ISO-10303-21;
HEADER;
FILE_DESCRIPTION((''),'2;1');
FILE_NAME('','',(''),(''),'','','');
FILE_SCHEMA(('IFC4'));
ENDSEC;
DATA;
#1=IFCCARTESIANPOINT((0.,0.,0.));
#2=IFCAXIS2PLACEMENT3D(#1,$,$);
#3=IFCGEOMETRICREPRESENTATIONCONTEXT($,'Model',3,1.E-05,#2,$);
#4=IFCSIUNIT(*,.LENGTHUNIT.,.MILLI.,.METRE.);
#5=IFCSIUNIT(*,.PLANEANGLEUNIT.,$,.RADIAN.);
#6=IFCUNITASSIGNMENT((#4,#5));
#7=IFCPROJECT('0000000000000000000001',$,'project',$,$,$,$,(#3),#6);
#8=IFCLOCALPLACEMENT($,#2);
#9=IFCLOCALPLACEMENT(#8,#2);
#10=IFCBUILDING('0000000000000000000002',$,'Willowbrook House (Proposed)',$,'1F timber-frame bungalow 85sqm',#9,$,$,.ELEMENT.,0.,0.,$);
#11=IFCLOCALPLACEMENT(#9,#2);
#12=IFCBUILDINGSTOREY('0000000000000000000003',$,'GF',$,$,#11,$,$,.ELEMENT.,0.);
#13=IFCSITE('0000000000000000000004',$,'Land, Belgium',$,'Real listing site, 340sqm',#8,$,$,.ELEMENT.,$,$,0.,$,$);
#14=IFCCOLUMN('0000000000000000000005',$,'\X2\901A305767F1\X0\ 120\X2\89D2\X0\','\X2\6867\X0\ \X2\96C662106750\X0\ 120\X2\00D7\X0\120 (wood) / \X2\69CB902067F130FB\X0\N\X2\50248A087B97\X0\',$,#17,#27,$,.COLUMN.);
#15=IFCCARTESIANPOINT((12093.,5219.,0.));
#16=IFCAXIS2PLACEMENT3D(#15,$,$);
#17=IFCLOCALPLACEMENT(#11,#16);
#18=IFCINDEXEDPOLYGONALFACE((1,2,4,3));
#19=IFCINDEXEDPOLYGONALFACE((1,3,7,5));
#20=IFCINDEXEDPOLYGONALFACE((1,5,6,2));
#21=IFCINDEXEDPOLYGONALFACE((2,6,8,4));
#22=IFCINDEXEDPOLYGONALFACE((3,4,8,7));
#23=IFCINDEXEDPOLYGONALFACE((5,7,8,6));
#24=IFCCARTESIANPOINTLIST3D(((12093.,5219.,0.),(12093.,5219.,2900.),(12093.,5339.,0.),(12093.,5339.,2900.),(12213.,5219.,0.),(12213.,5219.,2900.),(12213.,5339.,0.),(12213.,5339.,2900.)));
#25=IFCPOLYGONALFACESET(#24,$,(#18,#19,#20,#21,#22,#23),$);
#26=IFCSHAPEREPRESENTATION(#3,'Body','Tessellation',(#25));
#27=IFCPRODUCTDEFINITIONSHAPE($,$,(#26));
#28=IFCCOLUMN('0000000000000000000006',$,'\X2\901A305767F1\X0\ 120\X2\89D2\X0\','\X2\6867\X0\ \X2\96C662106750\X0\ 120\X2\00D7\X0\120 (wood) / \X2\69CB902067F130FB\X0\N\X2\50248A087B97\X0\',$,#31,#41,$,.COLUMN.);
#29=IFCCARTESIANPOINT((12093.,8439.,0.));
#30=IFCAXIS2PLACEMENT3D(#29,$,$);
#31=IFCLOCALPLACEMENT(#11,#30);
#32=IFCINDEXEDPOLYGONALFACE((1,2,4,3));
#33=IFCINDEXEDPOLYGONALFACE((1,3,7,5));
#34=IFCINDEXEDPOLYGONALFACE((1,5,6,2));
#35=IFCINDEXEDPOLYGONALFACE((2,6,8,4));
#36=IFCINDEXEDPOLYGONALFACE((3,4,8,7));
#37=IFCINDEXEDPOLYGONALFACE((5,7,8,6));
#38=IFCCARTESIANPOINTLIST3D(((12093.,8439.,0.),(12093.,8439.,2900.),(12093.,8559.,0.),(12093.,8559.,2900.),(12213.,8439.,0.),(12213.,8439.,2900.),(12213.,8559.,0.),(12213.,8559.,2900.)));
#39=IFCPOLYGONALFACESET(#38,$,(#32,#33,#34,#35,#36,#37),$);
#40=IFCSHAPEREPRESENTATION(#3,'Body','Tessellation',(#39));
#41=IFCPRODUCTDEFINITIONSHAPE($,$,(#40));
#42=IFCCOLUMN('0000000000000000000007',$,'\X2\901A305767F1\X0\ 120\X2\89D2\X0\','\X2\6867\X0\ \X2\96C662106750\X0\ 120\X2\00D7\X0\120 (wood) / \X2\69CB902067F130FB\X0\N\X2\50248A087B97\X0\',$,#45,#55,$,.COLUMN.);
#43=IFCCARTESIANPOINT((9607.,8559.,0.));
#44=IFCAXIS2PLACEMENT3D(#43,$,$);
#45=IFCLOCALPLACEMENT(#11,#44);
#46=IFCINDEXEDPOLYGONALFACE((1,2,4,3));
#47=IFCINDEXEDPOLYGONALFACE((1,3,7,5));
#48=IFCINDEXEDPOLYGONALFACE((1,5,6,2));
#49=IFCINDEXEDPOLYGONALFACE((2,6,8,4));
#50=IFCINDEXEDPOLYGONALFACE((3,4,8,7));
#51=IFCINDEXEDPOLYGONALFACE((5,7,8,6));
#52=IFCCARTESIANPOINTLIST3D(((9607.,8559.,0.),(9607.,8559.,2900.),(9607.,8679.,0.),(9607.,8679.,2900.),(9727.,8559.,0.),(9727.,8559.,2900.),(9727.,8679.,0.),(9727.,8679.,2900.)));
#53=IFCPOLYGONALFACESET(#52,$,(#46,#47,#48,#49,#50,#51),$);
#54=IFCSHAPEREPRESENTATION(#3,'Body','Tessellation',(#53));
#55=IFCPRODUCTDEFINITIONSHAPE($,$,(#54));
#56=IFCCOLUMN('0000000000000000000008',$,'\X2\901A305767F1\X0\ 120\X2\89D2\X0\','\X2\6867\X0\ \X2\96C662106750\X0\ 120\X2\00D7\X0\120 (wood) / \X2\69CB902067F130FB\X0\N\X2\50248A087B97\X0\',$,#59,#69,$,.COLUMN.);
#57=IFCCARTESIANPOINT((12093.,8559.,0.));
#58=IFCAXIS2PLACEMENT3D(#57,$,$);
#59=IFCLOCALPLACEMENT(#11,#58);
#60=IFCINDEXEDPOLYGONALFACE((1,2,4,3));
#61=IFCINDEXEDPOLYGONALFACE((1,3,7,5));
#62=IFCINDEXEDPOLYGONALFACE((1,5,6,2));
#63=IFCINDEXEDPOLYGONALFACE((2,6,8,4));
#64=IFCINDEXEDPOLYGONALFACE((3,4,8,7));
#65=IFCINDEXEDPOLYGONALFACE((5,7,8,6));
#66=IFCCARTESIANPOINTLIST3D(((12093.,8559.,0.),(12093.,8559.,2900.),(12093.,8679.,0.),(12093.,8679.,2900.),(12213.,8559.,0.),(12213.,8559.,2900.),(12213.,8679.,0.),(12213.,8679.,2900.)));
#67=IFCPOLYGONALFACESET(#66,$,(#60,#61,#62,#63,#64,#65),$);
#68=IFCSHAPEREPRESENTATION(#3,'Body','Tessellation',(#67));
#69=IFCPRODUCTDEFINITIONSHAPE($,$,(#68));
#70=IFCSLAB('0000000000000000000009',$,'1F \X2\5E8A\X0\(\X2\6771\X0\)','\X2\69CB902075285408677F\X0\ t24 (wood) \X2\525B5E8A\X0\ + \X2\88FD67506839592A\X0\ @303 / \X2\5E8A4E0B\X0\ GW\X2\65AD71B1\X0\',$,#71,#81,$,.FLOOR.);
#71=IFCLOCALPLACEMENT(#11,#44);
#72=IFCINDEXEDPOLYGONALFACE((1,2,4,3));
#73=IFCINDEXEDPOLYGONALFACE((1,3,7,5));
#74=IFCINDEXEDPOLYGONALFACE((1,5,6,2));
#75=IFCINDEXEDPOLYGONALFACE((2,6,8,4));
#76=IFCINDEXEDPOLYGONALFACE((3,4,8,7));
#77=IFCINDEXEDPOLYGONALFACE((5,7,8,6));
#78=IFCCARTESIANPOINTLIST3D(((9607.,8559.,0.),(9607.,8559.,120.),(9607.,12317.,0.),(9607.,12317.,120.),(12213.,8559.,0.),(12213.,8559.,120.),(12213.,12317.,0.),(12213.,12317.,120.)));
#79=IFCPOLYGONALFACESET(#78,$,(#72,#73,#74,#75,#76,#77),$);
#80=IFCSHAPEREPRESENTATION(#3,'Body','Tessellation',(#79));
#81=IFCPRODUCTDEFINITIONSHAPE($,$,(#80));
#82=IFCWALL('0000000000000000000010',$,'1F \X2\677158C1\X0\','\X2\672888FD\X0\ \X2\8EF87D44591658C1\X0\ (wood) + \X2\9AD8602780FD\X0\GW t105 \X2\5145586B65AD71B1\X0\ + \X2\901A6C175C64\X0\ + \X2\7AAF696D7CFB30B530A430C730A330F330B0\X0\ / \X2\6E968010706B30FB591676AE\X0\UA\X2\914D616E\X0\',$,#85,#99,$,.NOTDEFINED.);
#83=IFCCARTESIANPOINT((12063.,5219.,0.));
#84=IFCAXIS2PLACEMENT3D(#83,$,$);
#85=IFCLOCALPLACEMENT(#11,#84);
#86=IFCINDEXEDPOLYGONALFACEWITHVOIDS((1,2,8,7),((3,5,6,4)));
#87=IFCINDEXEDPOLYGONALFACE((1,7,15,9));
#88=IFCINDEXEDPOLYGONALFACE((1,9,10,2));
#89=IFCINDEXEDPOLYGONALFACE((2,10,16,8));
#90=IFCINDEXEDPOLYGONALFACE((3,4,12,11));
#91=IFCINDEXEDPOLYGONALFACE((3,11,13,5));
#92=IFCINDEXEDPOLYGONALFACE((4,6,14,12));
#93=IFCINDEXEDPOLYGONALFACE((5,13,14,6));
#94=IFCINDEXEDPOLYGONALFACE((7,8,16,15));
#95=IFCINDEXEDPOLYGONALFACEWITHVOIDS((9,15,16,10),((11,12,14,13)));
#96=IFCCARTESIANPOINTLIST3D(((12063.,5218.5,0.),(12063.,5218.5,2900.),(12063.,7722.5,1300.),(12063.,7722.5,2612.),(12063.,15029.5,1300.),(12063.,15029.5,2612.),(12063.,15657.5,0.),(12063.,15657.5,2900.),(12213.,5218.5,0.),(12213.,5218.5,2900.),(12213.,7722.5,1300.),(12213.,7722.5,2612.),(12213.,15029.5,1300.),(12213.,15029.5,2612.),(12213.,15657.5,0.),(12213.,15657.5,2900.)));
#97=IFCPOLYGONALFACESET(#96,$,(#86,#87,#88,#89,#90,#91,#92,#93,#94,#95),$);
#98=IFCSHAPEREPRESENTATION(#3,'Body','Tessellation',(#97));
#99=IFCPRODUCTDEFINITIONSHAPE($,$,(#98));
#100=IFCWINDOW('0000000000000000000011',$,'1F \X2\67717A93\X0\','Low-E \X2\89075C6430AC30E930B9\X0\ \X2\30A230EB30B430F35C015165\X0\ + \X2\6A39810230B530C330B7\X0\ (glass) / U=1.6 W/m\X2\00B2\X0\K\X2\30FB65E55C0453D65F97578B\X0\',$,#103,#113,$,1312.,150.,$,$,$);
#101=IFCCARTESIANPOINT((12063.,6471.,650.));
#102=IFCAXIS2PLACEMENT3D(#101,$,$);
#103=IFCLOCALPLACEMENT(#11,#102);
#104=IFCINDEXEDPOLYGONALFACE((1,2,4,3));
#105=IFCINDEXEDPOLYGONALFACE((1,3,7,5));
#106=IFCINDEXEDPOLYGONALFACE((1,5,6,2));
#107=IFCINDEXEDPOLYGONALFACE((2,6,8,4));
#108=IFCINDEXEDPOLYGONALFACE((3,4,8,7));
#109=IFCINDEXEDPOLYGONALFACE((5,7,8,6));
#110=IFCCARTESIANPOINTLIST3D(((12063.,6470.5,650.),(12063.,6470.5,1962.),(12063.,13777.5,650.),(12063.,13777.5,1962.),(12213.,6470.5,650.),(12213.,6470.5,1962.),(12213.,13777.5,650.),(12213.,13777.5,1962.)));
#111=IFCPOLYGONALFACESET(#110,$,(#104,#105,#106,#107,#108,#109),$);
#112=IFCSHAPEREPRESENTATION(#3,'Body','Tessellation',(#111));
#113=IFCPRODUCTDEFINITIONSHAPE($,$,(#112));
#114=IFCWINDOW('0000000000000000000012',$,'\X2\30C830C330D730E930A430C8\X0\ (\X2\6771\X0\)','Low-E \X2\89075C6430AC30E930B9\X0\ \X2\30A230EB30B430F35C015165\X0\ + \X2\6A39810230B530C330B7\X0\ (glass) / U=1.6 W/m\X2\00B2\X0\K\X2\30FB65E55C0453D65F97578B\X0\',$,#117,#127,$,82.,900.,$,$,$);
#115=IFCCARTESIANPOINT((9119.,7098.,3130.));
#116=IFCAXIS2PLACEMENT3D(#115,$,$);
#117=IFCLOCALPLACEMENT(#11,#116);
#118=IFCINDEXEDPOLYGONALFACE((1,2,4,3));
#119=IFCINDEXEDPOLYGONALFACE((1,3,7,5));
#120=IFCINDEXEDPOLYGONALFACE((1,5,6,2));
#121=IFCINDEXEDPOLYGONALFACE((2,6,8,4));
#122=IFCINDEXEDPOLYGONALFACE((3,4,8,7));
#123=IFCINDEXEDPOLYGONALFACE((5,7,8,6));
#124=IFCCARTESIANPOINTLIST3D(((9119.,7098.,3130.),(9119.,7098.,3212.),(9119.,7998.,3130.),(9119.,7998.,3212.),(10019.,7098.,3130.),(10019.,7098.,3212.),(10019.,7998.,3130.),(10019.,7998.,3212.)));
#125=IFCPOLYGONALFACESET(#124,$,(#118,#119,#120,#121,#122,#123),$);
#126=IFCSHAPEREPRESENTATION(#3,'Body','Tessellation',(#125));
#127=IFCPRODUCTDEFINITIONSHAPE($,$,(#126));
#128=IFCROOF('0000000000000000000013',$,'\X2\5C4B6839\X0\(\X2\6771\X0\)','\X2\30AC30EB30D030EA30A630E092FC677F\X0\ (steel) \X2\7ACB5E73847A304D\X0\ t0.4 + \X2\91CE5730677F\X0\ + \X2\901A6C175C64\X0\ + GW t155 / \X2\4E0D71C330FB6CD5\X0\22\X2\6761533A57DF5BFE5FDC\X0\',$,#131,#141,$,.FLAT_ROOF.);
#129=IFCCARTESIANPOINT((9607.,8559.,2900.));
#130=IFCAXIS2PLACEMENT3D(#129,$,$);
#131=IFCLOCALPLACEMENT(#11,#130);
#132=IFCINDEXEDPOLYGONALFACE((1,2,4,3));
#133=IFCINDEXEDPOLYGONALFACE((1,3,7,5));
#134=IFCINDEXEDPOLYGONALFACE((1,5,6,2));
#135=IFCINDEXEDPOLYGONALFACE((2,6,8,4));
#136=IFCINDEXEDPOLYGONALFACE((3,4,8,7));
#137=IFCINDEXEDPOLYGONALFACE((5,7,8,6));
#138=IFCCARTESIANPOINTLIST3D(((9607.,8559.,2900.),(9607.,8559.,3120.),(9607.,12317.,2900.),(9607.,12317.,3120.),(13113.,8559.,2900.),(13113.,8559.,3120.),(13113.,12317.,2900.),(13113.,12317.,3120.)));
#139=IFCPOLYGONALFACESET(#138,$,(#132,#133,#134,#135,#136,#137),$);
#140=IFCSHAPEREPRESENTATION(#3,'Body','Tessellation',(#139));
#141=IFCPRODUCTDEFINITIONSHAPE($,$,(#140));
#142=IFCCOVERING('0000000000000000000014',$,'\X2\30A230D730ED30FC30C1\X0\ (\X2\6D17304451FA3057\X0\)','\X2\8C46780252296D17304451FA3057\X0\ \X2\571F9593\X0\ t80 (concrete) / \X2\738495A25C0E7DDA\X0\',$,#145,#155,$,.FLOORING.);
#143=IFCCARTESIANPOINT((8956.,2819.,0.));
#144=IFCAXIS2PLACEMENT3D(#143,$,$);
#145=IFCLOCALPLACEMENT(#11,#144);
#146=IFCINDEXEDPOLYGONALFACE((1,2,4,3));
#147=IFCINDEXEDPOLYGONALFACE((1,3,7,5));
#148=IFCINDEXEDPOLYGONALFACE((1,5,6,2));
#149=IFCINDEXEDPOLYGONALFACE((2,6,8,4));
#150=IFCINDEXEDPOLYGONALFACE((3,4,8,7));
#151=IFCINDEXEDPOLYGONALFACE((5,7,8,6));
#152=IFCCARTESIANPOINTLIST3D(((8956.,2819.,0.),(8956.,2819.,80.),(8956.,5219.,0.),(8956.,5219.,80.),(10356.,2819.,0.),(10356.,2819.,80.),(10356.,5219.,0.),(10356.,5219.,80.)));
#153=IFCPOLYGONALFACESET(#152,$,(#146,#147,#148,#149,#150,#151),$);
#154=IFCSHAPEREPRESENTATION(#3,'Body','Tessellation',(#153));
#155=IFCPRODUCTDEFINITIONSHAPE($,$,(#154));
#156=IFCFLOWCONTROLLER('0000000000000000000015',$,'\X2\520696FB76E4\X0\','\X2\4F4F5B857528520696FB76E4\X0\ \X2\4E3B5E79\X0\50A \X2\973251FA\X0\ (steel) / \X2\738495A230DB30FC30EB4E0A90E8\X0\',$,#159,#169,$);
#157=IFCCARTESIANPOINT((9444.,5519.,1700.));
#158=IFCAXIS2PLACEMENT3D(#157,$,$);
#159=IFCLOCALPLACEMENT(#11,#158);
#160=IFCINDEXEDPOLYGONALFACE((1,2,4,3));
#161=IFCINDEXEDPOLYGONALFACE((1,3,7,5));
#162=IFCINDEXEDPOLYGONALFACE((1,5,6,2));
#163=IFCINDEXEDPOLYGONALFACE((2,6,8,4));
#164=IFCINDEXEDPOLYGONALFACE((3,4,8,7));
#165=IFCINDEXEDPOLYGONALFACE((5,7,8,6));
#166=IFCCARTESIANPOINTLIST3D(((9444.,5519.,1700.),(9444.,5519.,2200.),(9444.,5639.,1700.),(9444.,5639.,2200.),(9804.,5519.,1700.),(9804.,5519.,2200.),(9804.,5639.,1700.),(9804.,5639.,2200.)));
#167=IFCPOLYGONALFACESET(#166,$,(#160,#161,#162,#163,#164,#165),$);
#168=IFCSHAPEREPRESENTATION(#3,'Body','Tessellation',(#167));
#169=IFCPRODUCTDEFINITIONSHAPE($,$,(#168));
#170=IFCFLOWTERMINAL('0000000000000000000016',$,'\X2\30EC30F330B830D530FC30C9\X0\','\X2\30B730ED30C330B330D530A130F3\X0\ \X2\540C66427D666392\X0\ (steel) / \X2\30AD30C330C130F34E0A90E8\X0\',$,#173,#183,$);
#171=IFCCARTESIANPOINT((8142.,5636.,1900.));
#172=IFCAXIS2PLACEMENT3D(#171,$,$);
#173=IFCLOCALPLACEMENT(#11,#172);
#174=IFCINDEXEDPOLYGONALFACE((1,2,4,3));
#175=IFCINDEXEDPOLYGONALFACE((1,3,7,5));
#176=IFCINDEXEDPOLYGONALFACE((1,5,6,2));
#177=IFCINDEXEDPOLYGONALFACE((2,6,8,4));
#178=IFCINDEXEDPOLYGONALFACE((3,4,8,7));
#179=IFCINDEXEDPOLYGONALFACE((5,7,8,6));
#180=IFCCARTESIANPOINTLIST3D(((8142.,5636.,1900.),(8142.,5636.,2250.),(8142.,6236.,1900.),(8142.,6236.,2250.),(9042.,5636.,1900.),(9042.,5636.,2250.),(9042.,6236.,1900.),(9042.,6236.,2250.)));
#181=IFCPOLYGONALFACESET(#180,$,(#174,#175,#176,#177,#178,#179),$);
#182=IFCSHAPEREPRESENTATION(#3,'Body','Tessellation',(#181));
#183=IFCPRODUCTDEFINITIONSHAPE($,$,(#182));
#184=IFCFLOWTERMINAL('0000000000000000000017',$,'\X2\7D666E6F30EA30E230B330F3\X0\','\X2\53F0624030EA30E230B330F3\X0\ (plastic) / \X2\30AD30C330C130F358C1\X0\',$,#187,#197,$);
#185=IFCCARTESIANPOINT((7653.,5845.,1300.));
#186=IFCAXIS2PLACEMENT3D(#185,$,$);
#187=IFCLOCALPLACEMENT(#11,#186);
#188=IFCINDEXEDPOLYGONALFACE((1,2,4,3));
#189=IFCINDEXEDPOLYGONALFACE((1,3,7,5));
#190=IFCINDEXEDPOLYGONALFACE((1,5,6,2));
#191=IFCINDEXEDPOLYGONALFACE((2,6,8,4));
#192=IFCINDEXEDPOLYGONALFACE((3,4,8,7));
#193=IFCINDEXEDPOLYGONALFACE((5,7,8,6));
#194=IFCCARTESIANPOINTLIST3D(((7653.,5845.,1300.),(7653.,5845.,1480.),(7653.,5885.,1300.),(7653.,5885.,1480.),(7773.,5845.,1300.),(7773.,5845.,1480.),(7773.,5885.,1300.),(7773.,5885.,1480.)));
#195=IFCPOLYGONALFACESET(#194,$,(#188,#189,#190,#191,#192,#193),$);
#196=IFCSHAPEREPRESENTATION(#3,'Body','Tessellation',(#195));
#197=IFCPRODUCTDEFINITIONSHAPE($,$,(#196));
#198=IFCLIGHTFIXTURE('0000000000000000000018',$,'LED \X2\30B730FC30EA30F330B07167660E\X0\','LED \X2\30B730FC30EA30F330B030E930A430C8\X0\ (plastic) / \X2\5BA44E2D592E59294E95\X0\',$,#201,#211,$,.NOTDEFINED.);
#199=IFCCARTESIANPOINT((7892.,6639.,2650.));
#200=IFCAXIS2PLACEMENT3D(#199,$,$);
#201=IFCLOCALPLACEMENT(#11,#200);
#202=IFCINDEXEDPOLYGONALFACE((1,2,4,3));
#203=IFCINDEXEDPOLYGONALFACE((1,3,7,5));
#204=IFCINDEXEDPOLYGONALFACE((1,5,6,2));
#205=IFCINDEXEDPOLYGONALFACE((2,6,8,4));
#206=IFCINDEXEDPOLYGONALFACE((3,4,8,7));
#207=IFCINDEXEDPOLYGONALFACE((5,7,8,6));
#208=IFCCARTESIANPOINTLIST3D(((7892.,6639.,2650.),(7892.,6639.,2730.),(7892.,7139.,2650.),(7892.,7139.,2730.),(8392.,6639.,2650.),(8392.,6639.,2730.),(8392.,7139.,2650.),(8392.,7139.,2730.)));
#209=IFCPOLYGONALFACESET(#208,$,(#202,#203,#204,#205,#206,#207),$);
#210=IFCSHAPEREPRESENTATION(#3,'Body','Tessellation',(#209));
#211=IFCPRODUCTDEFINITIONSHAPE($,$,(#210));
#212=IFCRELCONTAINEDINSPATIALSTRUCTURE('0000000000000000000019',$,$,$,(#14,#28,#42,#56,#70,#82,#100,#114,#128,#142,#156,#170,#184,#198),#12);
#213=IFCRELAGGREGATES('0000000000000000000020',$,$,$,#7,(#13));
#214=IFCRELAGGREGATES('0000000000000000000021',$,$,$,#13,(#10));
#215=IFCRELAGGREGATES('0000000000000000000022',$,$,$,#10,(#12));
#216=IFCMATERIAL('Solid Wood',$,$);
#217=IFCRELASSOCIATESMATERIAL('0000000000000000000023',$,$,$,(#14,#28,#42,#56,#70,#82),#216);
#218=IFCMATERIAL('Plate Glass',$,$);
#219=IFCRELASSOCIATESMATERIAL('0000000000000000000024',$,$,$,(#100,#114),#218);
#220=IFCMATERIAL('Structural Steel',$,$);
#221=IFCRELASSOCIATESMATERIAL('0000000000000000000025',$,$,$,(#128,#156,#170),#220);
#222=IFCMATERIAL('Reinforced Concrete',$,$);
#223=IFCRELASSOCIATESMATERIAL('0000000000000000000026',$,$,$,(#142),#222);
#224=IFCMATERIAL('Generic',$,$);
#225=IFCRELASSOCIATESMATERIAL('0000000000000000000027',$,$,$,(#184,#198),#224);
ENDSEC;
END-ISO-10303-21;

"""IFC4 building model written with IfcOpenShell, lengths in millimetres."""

from ifc_helpers import new_model, si_unit, frame, frame_2d, origin, place, context, project, spatial, rectangle, extrude, material, element, fill, save


model = new_model("IFC4")

# Units and contexts
model_context = context("Model", 3, precision=1e-05, world=origin())
ifc_project = project(units=[si_unit("LENGTHUNIT", "METRE", prefix="MILLI"), si_unit("PLANEANGLEUNIT", "RADIAN")], contexts=[model_context])

# Site, building, storey
site_placement = place(None, origin())
site = spatial("IfcSite", under=ifc_project, at=site_placement, Name="Land, Belgium", ObjectType="Real listing site, 340sqm", CompositionType="ELEMENT", RefElevation=0.0)
building_placement = place(site_placement, origin())
building = spatial("IfcBuilding", under=site, at=building_placement, Name="Willowbrook House (Proposed)", ObjectType="1F timber-frame bungalow 85sqm", CompositionType="ELEMENT", ElevationOfRefHeight=0.0, ElevationOfTerrain=0.0)
storey_placement = place(building_placement, origin())
storey = spatial("IfcBuildingStorey", under=building, at=storey_placement, Name="GF", CompositionType="ELEMENT", Elevation=0.0)

# Columns
ifc_material_1 = material(Name="Solid Wood")
column_1_placement = place(storey_placement, frame((12093.0, 5219.0, 0.0)))
element("IfcColumn", 1, at=column_1_placement, inside=storey, material=ifc_material_1, Name="通し柱 120角", Description="桧 集成材 120×120 (wood) / 構造柱・N値計算", PredefinedType="COLUMN", context=model_context, shape_type="SweptSolid", body=[
    extrude(rectangle(XDim=120.0, YDim=120.0, at=frame_2d((60.0, 60.0))), frame((12093.0, 5219.0, 0.0)), (0.0, 0.0, 1.0), 2900.0),
])
column_2_placement = place(storey_placement, frame((12093.0, 8439.0, 0.0)))
element("IfcColumn", 2, at=column_2_placement, inside=storey, material=ifc_material_1, Name="通し柱 120角", Description="桧 集成材 120×120 (wood) / 構造柱・N値計算", PredefinedType="COLUMN", context=model_context, shape_type="SweptSolid", body=[
    extrude(rectangle(XDim=120.0, YDim=120.0, at=frame_2d((60.0, 60.0))), frame((12093.0, 8439.0, 0.0)), (0.0, 0.0, 1.0), 2900.0),
])
column_3_placement = place(storey_placement, frame((9607.0, 8559.0, 0.0)))
element("IfcColumn", 3, at=column_3_placement, inside=storey, material=ifc_material_1, Name="通し柱 120角", Description="桧 集成材 120×120 (wood) / 構造柱・N値計算", PredefinedType="COLUMN", context=model_context, shape_type="SweptSolid", body=[
    extrude(rectangle(XDim=120.0, YDim=120.0, at=frame_2d((60.0, 60.0))), frame((9607.0, 8559.0, 0.0)), (0.0, 0.0, 1.0), 2900.0),
])
column_4_placement = place(storey_placement, frame((12093.0, 8559.0, 0.0)))
element("IfcColumn", 4, at=column_4_placement, inside=storey, material=ifc_material_1, Name="通し柱 120角", Description="桧 集成材 120×120 (wood) / 構造柱・N値計算", PredefinedType="COLUMN", context=model_context, shape_type="SweptSolid", body=[
    extrude(rectangle(XDim=120.0, YDim=120.0, at=frame_2d((60.0, 60.0))), frame((12093.0, 8559.0, 0.0)), (0.0, 0.0, 1.0), 2900.0),
])

# Slab
slab_placement = place(storey_placement, frame((9607.0, 8559.0, 0.0)))
element("IfcSlab", 5, at=slab_placement, inside=storey, material=ifc_material_1, Name="1F 床(東)", Description="構造用合板 t24 (wood) 剛床 + 製材根太 @303 / 床下 GW断熱", PredefinedType="FLOOR", context=model_context, shape_type="SweptSolid", body=[
    extrude(rectangle(XDim=2606.0, YDim=3758.0, at=frame_2d((1303.0, 1879.0))), frame((9607.0, 8559.0, 0.0)), (0.0, 0.0, 1.0), 120.0),
])

# Wall, opening, window
wall_1_placement = place(storey_placement, frame((12063.0, 5219.0, 0.0)))
wall_1 = element("IfcWall", 6, at=wall_1_placement, inside=storey, material=ifc_material_1, Name="1F 東壁", Description="木製 軸組外壁 (wood) + 高性能GW t105 充填断熱 + 通気層 + 窯業系サイディング / 準耐火・外皮UA配慮", PredefinedType="NOTDEFINED", context=model_context, shape_type="SweptSolid", body=[
    extrude(rectangle(XDim=150.0, YDim=10439.0, at=frame_2d((75.0, 5219.0))), frame((12063.0, 5219.0, 0.0)), (0.0, 0.0, 1.0), 2900.0),
])
opening_placement = place(storey_placement, frame((12063.0, 6471.0, 650.0)))
opening = element("IfcOpeningElement", 7, at=opening_placement, cuts=wall_1, PredefinedType="NOTDEFINED", context=model_context, shape_type="SweptSolid", body=[
    extrude(rectangle(XDim=150.0, YDim=7307.0, at=frame_2d((75.0, 3653.0))), frame((12063.0, 6471.0, 650.0)), (0.0, 0.0, 1.0), 1312.0),
])
ifc_material_2 = material(Name="Plate Glass")
window_1_placement = place(storey_placement, frame((12063.0, 6471.0, 650.0)))
window_1 = element("IfcWindow", 8, at=window_1_placement, inside=storey, material=ifc_material_2, Name="1F 東窓", Description="Low-E 複層ガラス アルゴン封入 + 樹脂サッシ (glass) / U=1.6 W/m²K・日射取得型", OverallHeight=1312.0, OverallWidth=150.0, context=model_context, shape_type="SweptSolid", body=[
    extrude(rectangle(XDim=150.0, YDim=7307.0, at=frame_2d((75.0, 3653.0))), frame((12063.0, 6471.0, 650.0)), (0.0, 0.0, 1.0), 1312.0),
])
fill(opening, window_1)

# Window
window_2_placement = place(storey_placement, frame((9119.0, 7098.0, 3130.0)))
element("IfcWindow", 9, at=window_2_placement, inside=storey, material=ifc_material_2, Name="トップライト (東)", Description="Low-E 複層ガラス アルゴン封入 + 樹脂サッシ (glass) / U=1.6 W/m²K・日射取得型", OverallHeight=82.0, OverallWidth=900.0, context=model_context, shape_type="SweptSolid", body=[
    extrude(rectangle(XDim=900.0, YDim=900.0, at=frame_2d((450.0, 450.0))), frame((9119.0, 7098.0, 3130.0)), (0.0, 0.0, 1.0), 82.0),
])

# Roof
ifc_material_3 = material(Name="Structural Steel")
roof_placement = place(storey_placement, frame((9607.0, 8559.0, 2900.0)))
element("IfcRoof", 10, at=roof_placement, inside=storey, material=ifc_material_3, Name="屋根(東)", Description="ガルバリウム鋼板 (steel) 立平葺き t0.4 + 野地板 + 通気層 + GW t155 / 不燃・法22条区域対応", PredefinedType="FLAT_ROOF", context=model_context, shape_type="SweptSolid", body=[
    extrude(rectangle(XDim=3506.0, YDim=3758.0, at=frame_2d((1753.0, 1879.0))), frame((9607.0, 8559.0, 2900.0)), (0.0, 0.0, 1.0), 220.0),
])

# Covering
ifc_material_4 = material(Name="Reinforced Concrete")
covering_placement = place(storey_placement, frame((8956.0, 2819.0, 0.0)))
element("IfcCovering", 11, at=covering_placement, inside=storey, material=ifc_material_4, Name="アプローチ (洗い出し)", Description="豆砂利洗い出し 土間 t80 (concrete) / 玄関導線", PredefinedType="FLOORING", context=model_context, shape_type="SweptSolid", body=[
    extrude(rectangle(XDim=1400.0, YDim=2400.0, at=frame_2d((700.0, 1200.0))), frame((8956.0, 2819.0, 0.0)), (0.0, 0.0, 1.0), 80.0),
])

# Flow controller
flow_controller_placement = place(storey_placement, frame((9444.0, 5519.0, 1700.0)))
element("IfcFlowController", 12, at=flow_controller_placement, inside=storey, material=ifc_material_3, Name="分電盤", Description="住宅用分電盤 主幹50A 露出 (steel) / 玄関ホール上部", context=model_context, shape_type="SweptSolid", body=[
    extrude(rectangle(XDim=360.0, YDim=120.0, at=frame_2d((180.0, 60.0))), frame((9444.0, 5519.0, 1700.0)), (0.0, 0.0, 1.0), 500.0),
])

# Flow terminals
flow_terminal_1_placement = place(storey_placement, frame((8142.0, 5636.0, 1900.0)))
element("IfcFlowTerminal", 13, at=flow_terminal_1_placement, inside=storey, material=ifc_material_3, Name="レンジフード", Description="シロッコファン 同時給排 (steel) / キッチン上部", context=model_context, shape_type="SweptSolid", body=[
    extrude(rectangle(XDim=900.0, YDim=600.0, at=frame_2d((450.0, 300.0))), frame((8142.0, 5636.0, 1900.0)), (0.0, 0.0, 1.0), 350.0),
])
ifc_material_5 = material(Name="Generic")
flow_terminal_2_placement = place(storey_placement, frame((7653.0, 5845.0, 1300.0)))
element("IfcFlowTerminal", 14, at=flow_terminal_2_placement, inside=storey, material=ifc_material_5, Name="給湯リモコン", Description="台所リモコン (plastic) / キッチン壁", context=model_context, shape_type="SweptSolid", body=[
    extrude(rectangle(XDim=120.0, YDim=40.0, at=frame_2d((60.0, 20.0))), frame((7653.0, 5845.0, 1300.0)), (0.0, 0.0, 1.0), 180.0),
])

# Light fixture
light_fixture_placement = place(storey_placement, frame((7892.0, 6639.0, 2650.0)))
element("IfcLightFixture", 15, at=light_fixture_placement, inside=storey, material=ifc_material_5, Name="LED シーリング照明", Description="LED シーリングライト (plastic) / 室中央天井", PredefinedType="NOTDEFINED", context=model_context, shape_type="SweptSolid", body=[
    extrude(rectangle(XDim=500.0, YDim=500.0, at=frame_2d((250.0, 250.0))), frame((7892.0, 6639.0, 2650.0)), (0.0, 0.0, 1.0), 80.0),
])

save(model, "model.ifc")
